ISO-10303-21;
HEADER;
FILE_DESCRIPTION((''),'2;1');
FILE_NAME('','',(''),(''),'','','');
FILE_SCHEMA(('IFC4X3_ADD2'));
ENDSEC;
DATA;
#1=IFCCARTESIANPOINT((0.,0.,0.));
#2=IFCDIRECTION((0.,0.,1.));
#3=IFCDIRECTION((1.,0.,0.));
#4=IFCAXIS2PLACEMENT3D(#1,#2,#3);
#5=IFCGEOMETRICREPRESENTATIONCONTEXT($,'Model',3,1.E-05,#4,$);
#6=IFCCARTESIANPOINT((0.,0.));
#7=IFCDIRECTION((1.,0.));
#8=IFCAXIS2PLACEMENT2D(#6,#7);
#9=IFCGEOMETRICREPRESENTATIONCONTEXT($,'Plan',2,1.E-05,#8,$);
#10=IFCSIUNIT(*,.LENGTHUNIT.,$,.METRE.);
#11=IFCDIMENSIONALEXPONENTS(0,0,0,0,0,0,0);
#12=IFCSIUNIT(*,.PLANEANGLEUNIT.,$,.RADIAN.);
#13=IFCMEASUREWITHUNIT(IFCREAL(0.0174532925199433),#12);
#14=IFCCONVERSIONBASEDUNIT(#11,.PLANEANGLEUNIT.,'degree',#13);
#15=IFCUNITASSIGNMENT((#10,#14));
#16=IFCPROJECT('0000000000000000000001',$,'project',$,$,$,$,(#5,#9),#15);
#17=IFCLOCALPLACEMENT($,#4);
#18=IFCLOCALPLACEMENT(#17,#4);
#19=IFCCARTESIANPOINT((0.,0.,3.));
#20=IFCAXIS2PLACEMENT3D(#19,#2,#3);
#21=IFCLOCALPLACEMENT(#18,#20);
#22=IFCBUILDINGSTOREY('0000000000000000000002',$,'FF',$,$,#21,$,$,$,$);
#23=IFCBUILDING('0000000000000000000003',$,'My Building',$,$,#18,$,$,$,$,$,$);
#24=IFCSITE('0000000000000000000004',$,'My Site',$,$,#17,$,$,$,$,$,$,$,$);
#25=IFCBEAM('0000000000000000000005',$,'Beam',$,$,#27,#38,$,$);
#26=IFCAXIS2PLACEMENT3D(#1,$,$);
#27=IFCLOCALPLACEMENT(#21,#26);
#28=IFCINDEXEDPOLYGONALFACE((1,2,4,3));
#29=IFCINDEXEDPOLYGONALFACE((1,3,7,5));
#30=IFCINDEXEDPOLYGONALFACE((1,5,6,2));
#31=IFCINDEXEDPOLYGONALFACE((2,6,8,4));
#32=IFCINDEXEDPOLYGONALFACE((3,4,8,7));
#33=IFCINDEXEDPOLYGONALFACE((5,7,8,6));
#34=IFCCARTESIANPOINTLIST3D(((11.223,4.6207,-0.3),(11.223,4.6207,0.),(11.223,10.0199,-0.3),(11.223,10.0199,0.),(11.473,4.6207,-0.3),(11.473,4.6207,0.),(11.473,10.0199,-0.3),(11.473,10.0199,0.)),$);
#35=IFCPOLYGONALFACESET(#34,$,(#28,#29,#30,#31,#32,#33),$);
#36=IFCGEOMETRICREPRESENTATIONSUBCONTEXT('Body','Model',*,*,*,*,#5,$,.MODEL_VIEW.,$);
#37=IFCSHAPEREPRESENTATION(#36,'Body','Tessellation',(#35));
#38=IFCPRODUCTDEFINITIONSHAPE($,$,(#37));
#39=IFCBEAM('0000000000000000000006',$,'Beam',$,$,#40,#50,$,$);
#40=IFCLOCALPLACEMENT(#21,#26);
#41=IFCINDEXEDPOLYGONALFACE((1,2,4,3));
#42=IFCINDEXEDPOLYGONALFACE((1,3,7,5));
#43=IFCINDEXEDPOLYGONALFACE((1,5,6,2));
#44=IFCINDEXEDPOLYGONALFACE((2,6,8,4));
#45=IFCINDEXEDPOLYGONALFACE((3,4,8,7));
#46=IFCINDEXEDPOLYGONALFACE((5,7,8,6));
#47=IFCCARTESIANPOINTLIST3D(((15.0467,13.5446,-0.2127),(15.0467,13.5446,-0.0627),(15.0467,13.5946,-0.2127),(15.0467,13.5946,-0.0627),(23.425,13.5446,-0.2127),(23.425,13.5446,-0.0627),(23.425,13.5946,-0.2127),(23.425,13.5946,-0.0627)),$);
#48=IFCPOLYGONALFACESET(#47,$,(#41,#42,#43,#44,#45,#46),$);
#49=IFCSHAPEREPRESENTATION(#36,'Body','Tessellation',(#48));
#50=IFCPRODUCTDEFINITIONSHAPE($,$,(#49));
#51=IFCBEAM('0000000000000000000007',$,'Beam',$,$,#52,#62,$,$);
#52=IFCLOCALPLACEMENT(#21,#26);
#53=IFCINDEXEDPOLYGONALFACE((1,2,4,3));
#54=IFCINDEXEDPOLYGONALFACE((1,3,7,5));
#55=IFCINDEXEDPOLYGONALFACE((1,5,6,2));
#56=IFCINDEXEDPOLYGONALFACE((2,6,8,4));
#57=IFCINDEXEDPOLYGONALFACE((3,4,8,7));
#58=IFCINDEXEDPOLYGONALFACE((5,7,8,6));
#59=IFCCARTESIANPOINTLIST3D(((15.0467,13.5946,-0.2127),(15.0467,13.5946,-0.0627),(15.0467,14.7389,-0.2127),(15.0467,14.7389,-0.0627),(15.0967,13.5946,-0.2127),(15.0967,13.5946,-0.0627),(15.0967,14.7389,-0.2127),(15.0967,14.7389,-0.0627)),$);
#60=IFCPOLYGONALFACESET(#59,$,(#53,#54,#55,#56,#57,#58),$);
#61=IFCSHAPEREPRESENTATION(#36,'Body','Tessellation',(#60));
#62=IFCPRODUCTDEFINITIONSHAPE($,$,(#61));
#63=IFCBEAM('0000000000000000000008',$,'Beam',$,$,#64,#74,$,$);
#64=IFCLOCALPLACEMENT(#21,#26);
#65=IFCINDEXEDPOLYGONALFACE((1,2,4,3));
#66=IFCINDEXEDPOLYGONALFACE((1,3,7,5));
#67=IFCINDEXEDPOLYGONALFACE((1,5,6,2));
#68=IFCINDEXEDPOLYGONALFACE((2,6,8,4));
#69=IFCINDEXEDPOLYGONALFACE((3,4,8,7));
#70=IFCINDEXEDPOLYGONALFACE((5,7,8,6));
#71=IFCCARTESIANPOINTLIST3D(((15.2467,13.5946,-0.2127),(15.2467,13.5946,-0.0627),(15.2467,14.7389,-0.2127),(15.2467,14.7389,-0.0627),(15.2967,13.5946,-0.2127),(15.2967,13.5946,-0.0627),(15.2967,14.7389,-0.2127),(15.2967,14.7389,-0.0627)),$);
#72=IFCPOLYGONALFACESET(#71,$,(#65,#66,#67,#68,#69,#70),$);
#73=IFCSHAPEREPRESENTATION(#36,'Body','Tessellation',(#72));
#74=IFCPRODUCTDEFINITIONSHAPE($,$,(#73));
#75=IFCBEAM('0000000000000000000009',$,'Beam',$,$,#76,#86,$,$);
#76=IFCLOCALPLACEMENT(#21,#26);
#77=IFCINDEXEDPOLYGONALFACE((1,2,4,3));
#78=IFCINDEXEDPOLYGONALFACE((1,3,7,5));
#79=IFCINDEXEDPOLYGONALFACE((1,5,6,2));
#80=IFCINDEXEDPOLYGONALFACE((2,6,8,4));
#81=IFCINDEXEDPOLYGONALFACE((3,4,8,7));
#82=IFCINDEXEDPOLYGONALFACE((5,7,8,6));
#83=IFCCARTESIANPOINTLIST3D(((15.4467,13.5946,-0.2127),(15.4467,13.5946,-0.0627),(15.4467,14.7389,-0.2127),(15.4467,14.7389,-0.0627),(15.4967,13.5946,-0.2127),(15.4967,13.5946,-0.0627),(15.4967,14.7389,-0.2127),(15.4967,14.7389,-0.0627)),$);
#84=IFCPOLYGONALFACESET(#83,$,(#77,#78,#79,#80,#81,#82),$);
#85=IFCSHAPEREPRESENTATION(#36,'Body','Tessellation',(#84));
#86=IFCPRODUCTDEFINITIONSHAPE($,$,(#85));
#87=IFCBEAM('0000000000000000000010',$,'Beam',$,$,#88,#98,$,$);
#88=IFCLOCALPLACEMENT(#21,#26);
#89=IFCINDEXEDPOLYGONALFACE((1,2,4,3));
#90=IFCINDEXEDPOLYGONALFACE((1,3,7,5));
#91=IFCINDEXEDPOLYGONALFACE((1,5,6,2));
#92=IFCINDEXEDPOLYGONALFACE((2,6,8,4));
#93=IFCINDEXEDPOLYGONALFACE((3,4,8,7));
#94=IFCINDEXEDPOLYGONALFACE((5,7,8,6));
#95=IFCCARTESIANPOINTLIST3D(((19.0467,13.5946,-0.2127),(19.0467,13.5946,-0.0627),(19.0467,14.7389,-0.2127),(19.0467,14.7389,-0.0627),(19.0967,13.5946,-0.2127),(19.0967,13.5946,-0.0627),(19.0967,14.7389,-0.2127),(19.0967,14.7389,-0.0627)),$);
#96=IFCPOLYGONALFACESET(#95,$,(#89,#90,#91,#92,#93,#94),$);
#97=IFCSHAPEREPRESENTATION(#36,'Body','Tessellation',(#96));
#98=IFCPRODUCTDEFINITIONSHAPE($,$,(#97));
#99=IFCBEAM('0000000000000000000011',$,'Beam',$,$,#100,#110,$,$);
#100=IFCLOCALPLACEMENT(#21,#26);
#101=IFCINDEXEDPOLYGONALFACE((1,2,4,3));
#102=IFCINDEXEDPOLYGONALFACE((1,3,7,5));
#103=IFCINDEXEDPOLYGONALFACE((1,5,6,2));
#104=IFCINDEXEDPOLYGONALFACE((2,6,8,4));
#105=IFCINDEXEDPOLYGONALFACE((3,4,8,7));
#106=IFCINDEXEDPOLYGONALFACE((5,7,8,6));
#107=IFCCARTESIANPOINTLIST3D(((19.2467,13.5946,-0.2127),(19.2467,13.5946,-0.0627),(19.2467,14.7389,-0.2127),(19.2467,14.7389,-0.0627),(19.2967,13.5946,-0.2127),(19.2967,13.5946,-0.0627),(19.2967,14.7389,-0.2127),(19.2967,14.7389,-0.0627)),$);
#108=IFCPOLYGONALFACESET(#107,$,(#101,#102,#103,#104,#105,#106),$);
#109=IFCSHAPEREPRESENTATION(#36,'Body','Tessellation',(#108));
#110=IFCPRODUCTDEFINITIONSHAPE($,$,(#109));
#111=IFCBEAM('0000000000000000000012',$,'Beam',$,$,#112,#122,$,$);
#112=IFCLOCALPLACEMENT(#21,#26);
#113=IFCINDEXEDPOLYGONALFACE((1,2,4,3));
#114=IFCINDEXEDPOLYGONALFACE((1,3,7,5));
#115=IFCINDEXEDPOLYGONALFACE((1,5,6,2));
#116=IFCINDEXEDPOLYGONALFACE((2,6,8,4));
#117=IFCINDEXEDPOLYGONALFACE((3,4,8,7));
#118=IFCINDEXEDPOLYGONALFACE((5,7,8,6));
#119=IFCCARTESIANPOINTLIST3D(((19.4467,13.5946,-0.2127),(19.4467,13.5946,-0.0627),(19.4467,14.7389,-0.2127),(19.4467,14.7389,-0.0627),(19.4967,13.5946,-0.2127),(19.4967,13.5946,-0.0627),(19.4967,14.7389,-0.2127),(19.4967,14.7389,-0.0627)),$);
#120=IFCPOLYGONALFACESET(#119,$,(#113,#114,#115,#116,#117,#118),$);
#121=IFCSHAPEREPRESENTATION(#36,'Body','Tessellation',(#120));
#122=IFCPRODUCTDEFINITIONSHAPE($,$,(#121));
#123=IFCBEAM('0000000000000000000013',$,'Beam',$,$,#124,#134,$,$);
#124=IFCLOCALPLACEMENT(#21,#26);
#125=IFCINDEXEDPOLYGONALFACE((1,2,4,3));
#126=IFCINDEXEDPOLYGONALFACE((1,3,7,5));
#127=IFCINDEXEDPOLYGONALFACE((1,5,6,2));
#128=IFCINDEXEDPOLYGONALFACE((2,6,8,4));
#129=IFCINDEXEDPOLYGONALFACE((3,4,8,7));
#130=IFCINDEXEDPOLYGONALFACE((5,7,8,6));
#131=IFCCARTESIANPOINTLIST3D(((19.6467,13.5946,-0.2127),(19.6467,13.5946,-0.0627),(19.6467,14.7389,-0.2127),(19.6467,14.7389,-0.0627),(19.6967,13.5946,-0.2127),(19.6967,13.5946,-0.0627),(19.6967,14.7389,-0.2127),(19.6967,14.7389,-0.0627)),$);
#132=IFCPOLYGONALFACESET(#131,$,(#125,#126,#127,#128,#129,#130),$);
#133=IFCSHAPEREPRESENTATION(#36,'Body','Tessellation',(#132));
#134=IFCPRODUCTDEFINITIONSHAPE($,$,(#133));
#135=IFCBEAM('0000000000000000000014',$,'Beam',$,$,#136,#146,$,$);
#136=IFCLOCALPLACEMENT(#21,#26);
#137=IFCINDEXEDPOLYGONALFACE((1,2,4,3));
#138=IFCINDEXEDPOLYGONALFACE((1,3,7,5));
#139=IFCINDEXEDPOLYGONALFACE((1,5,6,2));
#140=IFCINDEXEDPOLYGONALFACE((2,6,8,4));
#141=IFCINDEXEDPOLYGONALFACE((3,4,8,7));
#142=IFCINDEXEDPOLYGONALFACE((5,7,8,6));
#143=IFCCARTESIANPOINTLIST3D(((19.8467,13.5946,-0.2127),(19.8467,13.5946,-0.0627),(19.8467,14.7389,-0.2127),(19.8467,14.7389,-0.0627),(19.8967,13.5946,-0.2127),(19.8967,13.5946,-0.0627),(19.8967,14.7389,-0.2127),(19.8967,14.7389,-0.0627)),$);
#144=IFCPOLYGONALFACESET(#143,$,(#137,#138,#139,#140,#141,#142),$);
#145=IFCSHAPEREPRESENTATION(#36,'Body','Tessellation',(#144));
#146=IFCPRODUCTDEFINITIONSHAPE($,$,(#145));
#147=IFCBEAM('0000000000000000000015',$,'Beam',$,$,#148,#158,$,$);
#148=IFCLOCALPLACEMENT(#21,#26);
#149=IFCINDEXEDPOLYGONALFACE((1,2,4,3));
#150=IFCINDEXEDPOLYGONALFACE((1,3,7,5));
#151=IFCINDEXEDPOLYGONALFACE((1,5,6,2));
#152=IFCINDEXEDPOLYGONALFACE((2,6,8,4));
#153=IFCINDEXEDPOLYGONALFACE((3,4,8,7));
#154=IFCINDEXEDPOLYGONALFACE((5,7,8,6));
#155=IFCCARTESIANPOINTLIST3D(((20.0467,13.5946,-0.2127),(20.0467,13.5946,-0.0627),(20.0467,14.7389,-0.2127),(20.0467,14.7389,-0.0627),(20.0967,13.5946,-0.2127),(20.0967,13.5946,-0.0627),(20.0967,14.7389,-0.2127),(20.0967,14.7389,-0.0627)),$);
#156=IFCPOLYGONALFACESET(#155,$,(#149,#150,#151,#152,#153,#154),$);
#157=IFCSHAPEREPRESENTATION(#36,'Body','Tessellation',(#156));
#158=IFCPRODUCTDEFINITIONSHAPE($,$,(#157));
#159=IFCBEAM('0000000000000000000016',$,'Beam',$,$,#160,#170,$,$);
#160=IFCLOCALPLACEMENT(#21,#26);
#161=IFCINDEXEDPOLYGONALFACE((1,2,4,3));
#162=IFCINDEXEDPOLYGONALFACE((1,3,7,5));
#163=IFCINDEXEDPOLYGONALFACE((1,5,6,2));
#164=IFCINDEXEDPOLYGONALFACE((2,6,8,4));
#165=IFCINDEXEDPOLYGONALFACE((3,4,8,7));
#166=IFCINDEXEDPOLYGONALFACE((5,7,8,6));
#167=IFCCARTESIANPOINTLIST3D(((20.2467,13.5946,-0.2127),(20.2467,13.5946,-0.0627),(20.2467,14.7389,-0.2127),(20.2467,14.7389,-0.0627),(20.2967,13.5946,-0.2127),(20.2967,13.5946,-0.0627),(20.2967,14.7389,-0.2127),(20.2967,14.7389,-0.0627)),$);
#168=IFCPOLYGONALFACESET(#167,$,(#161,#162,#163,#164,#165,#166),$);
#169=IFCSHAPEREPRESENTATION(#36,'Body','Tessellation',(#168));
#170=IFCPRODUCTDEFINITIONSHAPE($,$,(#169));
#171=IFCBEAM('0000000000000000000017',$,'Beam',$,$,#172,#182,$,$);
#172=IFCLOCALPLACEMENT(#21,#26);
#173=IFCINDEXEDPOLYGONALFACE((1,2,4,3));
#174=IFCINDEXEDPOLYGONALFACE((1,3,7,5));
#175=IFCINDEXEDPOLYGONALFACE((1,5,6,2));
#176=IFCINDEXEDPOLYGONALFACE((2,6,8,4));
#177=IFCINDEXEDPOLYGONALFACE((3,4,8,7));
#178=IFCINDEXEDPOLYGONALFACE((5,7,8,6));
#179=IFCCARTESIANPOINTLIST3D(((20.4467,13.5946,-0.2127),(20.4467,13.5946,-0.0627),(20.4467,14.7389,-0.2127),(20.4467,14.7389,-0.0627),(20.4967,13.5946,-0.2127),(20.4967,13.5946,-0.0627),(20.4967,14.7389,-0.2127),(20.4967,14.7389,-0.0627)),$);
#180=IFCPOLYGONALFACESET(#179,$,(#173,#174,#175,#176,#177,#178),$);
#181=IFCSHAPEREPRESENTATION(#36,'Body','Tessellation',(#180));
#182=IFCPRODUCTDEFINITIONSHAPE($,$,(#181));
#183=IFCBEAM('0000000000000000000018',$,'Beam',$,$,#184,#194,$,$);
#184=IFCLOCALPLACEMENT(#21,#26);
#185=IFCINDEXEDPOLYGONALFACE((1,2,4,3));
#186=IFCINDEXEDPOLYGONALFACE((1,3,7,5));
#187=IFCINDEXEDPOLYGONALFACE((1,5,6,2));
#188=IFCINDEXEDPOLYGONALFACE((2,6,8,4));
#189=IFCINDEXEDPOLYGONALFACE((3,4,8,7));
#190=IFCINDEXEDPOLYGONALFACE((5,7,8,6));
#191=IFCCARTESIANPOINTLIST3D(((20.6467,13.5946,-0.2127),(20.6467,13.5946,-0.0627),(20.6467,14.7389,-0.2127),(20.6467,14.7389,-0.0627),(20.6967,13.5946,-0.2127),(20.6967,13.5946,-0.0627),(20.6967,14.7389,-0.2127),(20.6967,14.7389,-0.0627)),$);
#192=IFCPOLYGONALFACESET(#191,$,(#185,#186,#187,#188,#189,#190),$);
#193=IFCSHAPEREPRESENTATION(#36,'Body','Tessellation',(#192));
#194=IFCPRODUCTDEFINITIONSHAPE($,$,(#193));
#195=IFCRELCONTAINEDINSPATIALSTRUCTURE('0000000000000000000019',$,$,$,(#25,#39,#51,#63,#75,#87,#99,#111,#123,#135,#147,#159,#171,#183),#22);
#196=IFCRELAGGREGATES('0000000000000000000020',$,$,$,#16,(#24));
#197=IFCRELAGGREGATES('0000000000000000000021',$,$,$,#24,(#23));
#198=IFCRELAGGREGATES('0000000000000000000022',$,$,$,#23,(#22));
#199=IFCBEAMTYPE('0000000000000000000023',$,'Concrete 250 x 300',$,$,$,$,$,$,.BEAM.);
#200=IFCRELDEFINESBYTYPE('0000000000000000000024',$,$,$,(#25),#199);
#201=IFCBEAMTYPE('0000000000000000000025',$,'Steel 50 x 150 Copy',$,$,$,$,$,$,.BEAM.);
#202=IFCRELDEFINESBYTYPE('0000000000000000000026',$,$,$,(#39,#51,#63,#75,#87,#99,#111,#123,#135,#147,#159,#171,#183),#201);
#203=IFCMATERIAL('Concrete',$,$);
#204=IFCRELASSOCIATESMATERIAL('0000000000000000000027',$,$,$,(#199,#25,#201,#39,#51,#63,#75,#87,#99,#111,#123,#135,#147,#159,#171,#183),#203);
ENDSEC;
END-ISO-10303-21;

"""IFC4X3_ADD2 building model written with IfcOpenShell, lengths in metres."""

from ifc_helpers import new_model, entity, si_unit, converted_unit, frame, origin_with_axes, origin_2d_with_axis, place, context, subcontext, project, spatial, rectangle, extrude, material, material_profile, profile_set, profile_usage, type_object, element, save


model = new_model("IFC4X3_ADD2")

# Units and contexts
model_context = context("Model", 3, precision=1e-05, world=origin_with_axes())
plan_context = context("Plan", 2, precision=1e-05, world=origin_2d_with_axis())
body_context = subcontext(model_context, "Body", "Model", "MODEL_VIEW")
ifc_project = project(units=[si_unit("LENGTHUNIT", "METRE"), converted_unit("PLANEANGLEUNIT", "degree", entity("IfcReal", 0.0174532925199433), si_unit("PLANEANGLEUNIT", "RADIAN"), dimensions=[0, 0, 0, 0, 0, 0, 0])], contexts=[model_context, plan_context])

# Site, building, storey
site_placement = place(None, origin_with_axes())
site = spatial("IfcSite", under=ifc_project, at=site_placement, Name="My Site")
building_placement = place(site_placement, origin_with_axes())
building = spatial("IfcBuilding", under=site, at=building_placement, Name="My Building")
storey_placement = place(building_placement, frame((0.0, 0.0, 3.0), z_axis=(0.0, 0.0, 1.0), x_axis=(1.0, 0.0, 0.0)))
storey = spatial("IfcBuildingStorey", under=building, at=storey_placement, Name="FF")

# Beams
ifc_material = material(Name="Concrete")
ifc_material_profile_1 = material_profile(ifc_material, rectangle(XDim=0.25, YDim=0.3))
ifc_profile_set_1 = profile_set([ifc_material_profile_1])
ifc_profile_usage_1 = profile_usage(ifc_profile_set_1, cardinal=8)
beam_type_1 = type_object("IfcBeamType", Name="Concrete 250 x 300", PredefinedType="BEAM", material=ifc_profile_set_1)
beam_1_placement = place(storey_placement, frame((11.348, 4.6207, 0.0), z_axis=(0.0, 1.0, 0.0), x_axis=(-1.0, 0.0, 0.0)))
element("IfcBeam", 1, at=beam_1_placement, inside=storey, type_object=beam_type_1, material=ifc_profile_usage_1, Name="Beam", context=body_context, shape_type="SweptSolid", body=[
    extrude(rectangle(XDim=0.25, YDim=0.3), frame((0.0, -0.15, 0.0), z_axis=(0.0, 0.0, 1.0), x_axis=(1.0, 0.0, 0.0)), (0.0, 0.0, 1.0), 5.3992),
])
ifc_material_profile_2 = material_profile(ifc_material, rectangle(XDim=0.05, YDim=0.15))
ifc_profile_set_2 = profile_set([ifc_material_profile_2])
ifc_profile_usage_2 = profile_usage(ifc_profile_set_2)
beam_type_2 = type_object("IfcBeamType", Name="Steel 50 x 150 Copy", PredefinedType="BEAM", material=ifc_profile_set_2)
beam_2_placement = place(storey_placement, frame((15.0467, 13.5696, -0.1377), z_axis=(1.0, 0.0, 0.0), x_axis=(0.0, 1.0, 0.0)))
element("IfcBeam", 2, at=beam_2_placement, inside=storey, type_object=beam_type_2, material=ifc_profile_usage_2, Name="Beam", context=body_context, shape_type="SweptSolid", body=[
    extrude(rectangle(XDim=0.05, YDim=0.15), origin_with_axes(), (0.0, 0.0, 1.0), 8.3783),
])
ifc_profile_usage_3 = profile_usage(ifc_profile_set_2)
beam_3_placement = place(storey_placement, frame((15.0717, 14.7389, -0.1377), z_axis=(0.0, -1.0, 0.0), x_axis=(1.0, 0.0, 0.0)))
element("IfcBeam", 3, at=beam_3_placement, inside=storey, type_object=beam_type_2, material=ifc_profile_usage_3, Name="Beam", context=body_context, shape_type="SweptSolid", body=[
    extrude(rectangle(XDim=0.05, YDim=0.15), origin_with_axes(), (0.0, 0.0, 1.0), 1.1444),
])
ifc_profile_usage_4 = profile_usage(ifc_profile_set_2)
beam_4_placement = place(storey_placement, frame((15.2717, 14.7389, -0.1377), z_axis=(0.0, -1.0, 0.0), x_axis=(1.0, 0.0, 0.0)))
element("IfcBeam", 4, at=beam_4_placement, inside=storey, type_object=beam_type_2, material=ifc_profile_usage_4, Name="Beam", context=body_context, shape_type="SweptSolid", body=[
    extrude(rectangle(XDim=0.05, YDim=0.15), origin_with_axes(), (0.0, 0.0, 1.0), 1.1444),
])
ifc_profile_usage_5 = profile_usage(ifc_profile_set_2)
beam_5_placement = place(storey_placement, frame((15.4717, 14.7389, -0.1377), z_axis=(0.0, -1.0, 0.0), x_axis=(1.0, 0.0, 0.0)))
element("IfcBeam", 5, at=beam_5_placement, inside=storey, type_object=beam_type_2, material=ifc_profile_usage_5, Name="Beam", context=body_context, shape_type="SweptSolid", body=[
    extrude(rectangle(XDim=0.05, YDim=0.15), origin_with_axes(), (0.0, 0.0, 1.0), 1.1444),
])
ifc_profile_usage_6 = profile_usage(ifc_profile_set_2)
beam_6_placement = place(storey_placement, frame((19.0717, 14.7389, -0.1377), z_axis=(0.0, -1.0, 0.0), x_axis=(1.0, 0.0, 0.0)))
element("IfcBeam", 6, at=beam_6_placement, inside=storey, type_object=beam_type_2, material=ifc_profile_usage_6, Name="Beam", context=body_context, shape_type="SweptSolid", body=[
    extrude(rectangle(XDim=0.05, YDim=0.15), origin_with_axes(), (0.0, 0.0, 1.0), 1.1444),
])
ifc_profile_usage_7 = profile_usage(ifc_profile_set_2)
beam_7_placement = place(storey_placement, frame((19.2717, 14.7389, -0.1377), z_axis=(0.0, -1.0, 0.0), x_axis=(1.0, 0.0, 0.0)))
element("IfcBeam", 7, at=beam_7_placement, inside=storey, type_object=beam_type_2, material=ifc_profile_usage_7, Name="Beam", context=body_context, shape_type="SweptSolid", body=[
    extrude(rectangle(XDim=0.05, YDim=0.15), origin_with_axes(), (0.0, 0.0, 1.0), 1.1444),
])
ifc_profile_usage_8 = profile_usage(ifc_profile_set_2)
beam_8_placement = place(storey_placement, frame((19.4717, 14.7389, -0.1377), z_axis=(0.0, -1.0, 0.0), x_axis=(1.0, 0.0, 0.0)))
element("IfcBeam", 8, at=beam_8_placement, inside=storey, type_object=beam_type_2, material=ifc_profile_usage_8, Name="Beam", context=body_context, shape_type="SweptSolid", body=[
    extrude(rectangle(XDim=0.05, YDim=0.15), origin_with_axes(), (0.0, 0.0, 1.0), 1.1444),
])
ifc_profile_usage_9 = profile_usage(ifc_profile_set_2)
beam_9_placement = place(storey_placement, frame((19.6717, 14.7389, -0.1377), z_axis=(0.0, -1.0, 0.0), x_axis=(1.0, 0.0, 0.0)))
element("IfcBeam", 9, at=beam_9_placement, inside=storey, type_object=beam_type_2, material=ifc_profile_usage_9, Name="Beam", context=body_context, shape_type="SweptSolid", body=[
    extrude(rectangle(XDim=0.05, YDim=0.15), origin_with_axes(), (0.0, 0.0, 1.0), 1.1444),
])
ifc_profile_usage_10 = profile_usage(ifc_profile_set_2)
beam_10_placement = place(storey_placement, frame((19.8717, 14.7389, -0.1377), z_axis=(0.0, -1.0, 0.0), x_axis=(1.0, 0.0, 0.0)))
element("IfcBeam", 10, at=beam_10_placement, inside=storey, type_object=beam_type_2, material=ifc_profile_usage_10, Name="Beam", context=body_context, shape_type="SweptSolid", body=[
    extrude(rectangle(XDim=0.05, YDim=0.15), origin_with_axes(), (0.0, 0.0, 1.0), 1.1444),
])
ifc_profile_usage_11 = profile_usage(ifc_profile_set_2)
beam_11_placement = place(storey_placement, frame((20.0717, 14.7389, -0.1377), z_axis=(0.0, -1.0, 0.0), x_axis=(1.0, 0.0, 0.0)))
element("IfcBeam", 11, at=beam_11_placement, inside=storey, type_object=beam_type_2, material=ifc_profile_usage_11, Name="Beam", context=body_context, shape_type="SweptSolid", body=[
    extrude(rectangle(XDim=0.05, YDim=0.15), origin_with_axes(), (0.0, 0.0, 1.0), 1.1444),
])
ifc_profile_usage_12 = profile_usage(ifc_profile_set_2)
beam_12_placement = place(storey_placement, frame((20.2717, 14.7389, -0.1377), z_axis=(0.0, -1.0, 0.0), x_axis=(1.0, 0.0, 0.0)))
element("IfcBeam", 12, at=beam_12_placement, inside=storey, type_object=beam_type_2, material=ifc_profile_usage_12, Name="Beam", context=body_context, shape_type="SweptSolid", body=[
    extrude(rectangle(XDim=0.05, YDim=0.15), origin_with_axes(), (0.0, 0.0, 1.0), 1.1444),
])
ifc_profile_usage_13 = profile_usage(ifc_profile_set_2)
beam_13_placement = place(storey_placement, frame((20.4717, 14.7389, -0.1377), z_axis=(0.0, -1.0, 0.0), x_axis=(1.0, 0.0, 0.0)))
element("IfcBeam", 13, at=beam_13_placement, inside=storey, type_object=beam_type_2, material=ifc_profile_usage_13, Name="Beam", context=body_context, shape_type="SweptSolid", body=[
    extrude(rectangle(XDim=0.05, YDim=0.15), origin_with_axes(), (0.0, 0.0, 1.0), 1.1444),
])
ifc_profile_usage_14 = profile_usage(ifc_profile_set_2)
beam_14_placement = place(storey_placement, frame((20.6717, 14.7389, -0.1377), z_axis=(0.0, -1.0, 0.0), x_axis=(1.0, 0.0, 0.0)))
element("IfcBeam", 14, at=beam_14_placement, inside=storey, type_object=beam_type_2, material=ifc_profile_usage_14, Name="Beam", context=body_context, shape_type="SweptSolid", body=[
    extrude(rectangle(XDim=0.05, YDim=0.15), origin_with_axes(), (0.0, 0.0, 1.0), 1.1444),
])

save(model, "model.ifc")
